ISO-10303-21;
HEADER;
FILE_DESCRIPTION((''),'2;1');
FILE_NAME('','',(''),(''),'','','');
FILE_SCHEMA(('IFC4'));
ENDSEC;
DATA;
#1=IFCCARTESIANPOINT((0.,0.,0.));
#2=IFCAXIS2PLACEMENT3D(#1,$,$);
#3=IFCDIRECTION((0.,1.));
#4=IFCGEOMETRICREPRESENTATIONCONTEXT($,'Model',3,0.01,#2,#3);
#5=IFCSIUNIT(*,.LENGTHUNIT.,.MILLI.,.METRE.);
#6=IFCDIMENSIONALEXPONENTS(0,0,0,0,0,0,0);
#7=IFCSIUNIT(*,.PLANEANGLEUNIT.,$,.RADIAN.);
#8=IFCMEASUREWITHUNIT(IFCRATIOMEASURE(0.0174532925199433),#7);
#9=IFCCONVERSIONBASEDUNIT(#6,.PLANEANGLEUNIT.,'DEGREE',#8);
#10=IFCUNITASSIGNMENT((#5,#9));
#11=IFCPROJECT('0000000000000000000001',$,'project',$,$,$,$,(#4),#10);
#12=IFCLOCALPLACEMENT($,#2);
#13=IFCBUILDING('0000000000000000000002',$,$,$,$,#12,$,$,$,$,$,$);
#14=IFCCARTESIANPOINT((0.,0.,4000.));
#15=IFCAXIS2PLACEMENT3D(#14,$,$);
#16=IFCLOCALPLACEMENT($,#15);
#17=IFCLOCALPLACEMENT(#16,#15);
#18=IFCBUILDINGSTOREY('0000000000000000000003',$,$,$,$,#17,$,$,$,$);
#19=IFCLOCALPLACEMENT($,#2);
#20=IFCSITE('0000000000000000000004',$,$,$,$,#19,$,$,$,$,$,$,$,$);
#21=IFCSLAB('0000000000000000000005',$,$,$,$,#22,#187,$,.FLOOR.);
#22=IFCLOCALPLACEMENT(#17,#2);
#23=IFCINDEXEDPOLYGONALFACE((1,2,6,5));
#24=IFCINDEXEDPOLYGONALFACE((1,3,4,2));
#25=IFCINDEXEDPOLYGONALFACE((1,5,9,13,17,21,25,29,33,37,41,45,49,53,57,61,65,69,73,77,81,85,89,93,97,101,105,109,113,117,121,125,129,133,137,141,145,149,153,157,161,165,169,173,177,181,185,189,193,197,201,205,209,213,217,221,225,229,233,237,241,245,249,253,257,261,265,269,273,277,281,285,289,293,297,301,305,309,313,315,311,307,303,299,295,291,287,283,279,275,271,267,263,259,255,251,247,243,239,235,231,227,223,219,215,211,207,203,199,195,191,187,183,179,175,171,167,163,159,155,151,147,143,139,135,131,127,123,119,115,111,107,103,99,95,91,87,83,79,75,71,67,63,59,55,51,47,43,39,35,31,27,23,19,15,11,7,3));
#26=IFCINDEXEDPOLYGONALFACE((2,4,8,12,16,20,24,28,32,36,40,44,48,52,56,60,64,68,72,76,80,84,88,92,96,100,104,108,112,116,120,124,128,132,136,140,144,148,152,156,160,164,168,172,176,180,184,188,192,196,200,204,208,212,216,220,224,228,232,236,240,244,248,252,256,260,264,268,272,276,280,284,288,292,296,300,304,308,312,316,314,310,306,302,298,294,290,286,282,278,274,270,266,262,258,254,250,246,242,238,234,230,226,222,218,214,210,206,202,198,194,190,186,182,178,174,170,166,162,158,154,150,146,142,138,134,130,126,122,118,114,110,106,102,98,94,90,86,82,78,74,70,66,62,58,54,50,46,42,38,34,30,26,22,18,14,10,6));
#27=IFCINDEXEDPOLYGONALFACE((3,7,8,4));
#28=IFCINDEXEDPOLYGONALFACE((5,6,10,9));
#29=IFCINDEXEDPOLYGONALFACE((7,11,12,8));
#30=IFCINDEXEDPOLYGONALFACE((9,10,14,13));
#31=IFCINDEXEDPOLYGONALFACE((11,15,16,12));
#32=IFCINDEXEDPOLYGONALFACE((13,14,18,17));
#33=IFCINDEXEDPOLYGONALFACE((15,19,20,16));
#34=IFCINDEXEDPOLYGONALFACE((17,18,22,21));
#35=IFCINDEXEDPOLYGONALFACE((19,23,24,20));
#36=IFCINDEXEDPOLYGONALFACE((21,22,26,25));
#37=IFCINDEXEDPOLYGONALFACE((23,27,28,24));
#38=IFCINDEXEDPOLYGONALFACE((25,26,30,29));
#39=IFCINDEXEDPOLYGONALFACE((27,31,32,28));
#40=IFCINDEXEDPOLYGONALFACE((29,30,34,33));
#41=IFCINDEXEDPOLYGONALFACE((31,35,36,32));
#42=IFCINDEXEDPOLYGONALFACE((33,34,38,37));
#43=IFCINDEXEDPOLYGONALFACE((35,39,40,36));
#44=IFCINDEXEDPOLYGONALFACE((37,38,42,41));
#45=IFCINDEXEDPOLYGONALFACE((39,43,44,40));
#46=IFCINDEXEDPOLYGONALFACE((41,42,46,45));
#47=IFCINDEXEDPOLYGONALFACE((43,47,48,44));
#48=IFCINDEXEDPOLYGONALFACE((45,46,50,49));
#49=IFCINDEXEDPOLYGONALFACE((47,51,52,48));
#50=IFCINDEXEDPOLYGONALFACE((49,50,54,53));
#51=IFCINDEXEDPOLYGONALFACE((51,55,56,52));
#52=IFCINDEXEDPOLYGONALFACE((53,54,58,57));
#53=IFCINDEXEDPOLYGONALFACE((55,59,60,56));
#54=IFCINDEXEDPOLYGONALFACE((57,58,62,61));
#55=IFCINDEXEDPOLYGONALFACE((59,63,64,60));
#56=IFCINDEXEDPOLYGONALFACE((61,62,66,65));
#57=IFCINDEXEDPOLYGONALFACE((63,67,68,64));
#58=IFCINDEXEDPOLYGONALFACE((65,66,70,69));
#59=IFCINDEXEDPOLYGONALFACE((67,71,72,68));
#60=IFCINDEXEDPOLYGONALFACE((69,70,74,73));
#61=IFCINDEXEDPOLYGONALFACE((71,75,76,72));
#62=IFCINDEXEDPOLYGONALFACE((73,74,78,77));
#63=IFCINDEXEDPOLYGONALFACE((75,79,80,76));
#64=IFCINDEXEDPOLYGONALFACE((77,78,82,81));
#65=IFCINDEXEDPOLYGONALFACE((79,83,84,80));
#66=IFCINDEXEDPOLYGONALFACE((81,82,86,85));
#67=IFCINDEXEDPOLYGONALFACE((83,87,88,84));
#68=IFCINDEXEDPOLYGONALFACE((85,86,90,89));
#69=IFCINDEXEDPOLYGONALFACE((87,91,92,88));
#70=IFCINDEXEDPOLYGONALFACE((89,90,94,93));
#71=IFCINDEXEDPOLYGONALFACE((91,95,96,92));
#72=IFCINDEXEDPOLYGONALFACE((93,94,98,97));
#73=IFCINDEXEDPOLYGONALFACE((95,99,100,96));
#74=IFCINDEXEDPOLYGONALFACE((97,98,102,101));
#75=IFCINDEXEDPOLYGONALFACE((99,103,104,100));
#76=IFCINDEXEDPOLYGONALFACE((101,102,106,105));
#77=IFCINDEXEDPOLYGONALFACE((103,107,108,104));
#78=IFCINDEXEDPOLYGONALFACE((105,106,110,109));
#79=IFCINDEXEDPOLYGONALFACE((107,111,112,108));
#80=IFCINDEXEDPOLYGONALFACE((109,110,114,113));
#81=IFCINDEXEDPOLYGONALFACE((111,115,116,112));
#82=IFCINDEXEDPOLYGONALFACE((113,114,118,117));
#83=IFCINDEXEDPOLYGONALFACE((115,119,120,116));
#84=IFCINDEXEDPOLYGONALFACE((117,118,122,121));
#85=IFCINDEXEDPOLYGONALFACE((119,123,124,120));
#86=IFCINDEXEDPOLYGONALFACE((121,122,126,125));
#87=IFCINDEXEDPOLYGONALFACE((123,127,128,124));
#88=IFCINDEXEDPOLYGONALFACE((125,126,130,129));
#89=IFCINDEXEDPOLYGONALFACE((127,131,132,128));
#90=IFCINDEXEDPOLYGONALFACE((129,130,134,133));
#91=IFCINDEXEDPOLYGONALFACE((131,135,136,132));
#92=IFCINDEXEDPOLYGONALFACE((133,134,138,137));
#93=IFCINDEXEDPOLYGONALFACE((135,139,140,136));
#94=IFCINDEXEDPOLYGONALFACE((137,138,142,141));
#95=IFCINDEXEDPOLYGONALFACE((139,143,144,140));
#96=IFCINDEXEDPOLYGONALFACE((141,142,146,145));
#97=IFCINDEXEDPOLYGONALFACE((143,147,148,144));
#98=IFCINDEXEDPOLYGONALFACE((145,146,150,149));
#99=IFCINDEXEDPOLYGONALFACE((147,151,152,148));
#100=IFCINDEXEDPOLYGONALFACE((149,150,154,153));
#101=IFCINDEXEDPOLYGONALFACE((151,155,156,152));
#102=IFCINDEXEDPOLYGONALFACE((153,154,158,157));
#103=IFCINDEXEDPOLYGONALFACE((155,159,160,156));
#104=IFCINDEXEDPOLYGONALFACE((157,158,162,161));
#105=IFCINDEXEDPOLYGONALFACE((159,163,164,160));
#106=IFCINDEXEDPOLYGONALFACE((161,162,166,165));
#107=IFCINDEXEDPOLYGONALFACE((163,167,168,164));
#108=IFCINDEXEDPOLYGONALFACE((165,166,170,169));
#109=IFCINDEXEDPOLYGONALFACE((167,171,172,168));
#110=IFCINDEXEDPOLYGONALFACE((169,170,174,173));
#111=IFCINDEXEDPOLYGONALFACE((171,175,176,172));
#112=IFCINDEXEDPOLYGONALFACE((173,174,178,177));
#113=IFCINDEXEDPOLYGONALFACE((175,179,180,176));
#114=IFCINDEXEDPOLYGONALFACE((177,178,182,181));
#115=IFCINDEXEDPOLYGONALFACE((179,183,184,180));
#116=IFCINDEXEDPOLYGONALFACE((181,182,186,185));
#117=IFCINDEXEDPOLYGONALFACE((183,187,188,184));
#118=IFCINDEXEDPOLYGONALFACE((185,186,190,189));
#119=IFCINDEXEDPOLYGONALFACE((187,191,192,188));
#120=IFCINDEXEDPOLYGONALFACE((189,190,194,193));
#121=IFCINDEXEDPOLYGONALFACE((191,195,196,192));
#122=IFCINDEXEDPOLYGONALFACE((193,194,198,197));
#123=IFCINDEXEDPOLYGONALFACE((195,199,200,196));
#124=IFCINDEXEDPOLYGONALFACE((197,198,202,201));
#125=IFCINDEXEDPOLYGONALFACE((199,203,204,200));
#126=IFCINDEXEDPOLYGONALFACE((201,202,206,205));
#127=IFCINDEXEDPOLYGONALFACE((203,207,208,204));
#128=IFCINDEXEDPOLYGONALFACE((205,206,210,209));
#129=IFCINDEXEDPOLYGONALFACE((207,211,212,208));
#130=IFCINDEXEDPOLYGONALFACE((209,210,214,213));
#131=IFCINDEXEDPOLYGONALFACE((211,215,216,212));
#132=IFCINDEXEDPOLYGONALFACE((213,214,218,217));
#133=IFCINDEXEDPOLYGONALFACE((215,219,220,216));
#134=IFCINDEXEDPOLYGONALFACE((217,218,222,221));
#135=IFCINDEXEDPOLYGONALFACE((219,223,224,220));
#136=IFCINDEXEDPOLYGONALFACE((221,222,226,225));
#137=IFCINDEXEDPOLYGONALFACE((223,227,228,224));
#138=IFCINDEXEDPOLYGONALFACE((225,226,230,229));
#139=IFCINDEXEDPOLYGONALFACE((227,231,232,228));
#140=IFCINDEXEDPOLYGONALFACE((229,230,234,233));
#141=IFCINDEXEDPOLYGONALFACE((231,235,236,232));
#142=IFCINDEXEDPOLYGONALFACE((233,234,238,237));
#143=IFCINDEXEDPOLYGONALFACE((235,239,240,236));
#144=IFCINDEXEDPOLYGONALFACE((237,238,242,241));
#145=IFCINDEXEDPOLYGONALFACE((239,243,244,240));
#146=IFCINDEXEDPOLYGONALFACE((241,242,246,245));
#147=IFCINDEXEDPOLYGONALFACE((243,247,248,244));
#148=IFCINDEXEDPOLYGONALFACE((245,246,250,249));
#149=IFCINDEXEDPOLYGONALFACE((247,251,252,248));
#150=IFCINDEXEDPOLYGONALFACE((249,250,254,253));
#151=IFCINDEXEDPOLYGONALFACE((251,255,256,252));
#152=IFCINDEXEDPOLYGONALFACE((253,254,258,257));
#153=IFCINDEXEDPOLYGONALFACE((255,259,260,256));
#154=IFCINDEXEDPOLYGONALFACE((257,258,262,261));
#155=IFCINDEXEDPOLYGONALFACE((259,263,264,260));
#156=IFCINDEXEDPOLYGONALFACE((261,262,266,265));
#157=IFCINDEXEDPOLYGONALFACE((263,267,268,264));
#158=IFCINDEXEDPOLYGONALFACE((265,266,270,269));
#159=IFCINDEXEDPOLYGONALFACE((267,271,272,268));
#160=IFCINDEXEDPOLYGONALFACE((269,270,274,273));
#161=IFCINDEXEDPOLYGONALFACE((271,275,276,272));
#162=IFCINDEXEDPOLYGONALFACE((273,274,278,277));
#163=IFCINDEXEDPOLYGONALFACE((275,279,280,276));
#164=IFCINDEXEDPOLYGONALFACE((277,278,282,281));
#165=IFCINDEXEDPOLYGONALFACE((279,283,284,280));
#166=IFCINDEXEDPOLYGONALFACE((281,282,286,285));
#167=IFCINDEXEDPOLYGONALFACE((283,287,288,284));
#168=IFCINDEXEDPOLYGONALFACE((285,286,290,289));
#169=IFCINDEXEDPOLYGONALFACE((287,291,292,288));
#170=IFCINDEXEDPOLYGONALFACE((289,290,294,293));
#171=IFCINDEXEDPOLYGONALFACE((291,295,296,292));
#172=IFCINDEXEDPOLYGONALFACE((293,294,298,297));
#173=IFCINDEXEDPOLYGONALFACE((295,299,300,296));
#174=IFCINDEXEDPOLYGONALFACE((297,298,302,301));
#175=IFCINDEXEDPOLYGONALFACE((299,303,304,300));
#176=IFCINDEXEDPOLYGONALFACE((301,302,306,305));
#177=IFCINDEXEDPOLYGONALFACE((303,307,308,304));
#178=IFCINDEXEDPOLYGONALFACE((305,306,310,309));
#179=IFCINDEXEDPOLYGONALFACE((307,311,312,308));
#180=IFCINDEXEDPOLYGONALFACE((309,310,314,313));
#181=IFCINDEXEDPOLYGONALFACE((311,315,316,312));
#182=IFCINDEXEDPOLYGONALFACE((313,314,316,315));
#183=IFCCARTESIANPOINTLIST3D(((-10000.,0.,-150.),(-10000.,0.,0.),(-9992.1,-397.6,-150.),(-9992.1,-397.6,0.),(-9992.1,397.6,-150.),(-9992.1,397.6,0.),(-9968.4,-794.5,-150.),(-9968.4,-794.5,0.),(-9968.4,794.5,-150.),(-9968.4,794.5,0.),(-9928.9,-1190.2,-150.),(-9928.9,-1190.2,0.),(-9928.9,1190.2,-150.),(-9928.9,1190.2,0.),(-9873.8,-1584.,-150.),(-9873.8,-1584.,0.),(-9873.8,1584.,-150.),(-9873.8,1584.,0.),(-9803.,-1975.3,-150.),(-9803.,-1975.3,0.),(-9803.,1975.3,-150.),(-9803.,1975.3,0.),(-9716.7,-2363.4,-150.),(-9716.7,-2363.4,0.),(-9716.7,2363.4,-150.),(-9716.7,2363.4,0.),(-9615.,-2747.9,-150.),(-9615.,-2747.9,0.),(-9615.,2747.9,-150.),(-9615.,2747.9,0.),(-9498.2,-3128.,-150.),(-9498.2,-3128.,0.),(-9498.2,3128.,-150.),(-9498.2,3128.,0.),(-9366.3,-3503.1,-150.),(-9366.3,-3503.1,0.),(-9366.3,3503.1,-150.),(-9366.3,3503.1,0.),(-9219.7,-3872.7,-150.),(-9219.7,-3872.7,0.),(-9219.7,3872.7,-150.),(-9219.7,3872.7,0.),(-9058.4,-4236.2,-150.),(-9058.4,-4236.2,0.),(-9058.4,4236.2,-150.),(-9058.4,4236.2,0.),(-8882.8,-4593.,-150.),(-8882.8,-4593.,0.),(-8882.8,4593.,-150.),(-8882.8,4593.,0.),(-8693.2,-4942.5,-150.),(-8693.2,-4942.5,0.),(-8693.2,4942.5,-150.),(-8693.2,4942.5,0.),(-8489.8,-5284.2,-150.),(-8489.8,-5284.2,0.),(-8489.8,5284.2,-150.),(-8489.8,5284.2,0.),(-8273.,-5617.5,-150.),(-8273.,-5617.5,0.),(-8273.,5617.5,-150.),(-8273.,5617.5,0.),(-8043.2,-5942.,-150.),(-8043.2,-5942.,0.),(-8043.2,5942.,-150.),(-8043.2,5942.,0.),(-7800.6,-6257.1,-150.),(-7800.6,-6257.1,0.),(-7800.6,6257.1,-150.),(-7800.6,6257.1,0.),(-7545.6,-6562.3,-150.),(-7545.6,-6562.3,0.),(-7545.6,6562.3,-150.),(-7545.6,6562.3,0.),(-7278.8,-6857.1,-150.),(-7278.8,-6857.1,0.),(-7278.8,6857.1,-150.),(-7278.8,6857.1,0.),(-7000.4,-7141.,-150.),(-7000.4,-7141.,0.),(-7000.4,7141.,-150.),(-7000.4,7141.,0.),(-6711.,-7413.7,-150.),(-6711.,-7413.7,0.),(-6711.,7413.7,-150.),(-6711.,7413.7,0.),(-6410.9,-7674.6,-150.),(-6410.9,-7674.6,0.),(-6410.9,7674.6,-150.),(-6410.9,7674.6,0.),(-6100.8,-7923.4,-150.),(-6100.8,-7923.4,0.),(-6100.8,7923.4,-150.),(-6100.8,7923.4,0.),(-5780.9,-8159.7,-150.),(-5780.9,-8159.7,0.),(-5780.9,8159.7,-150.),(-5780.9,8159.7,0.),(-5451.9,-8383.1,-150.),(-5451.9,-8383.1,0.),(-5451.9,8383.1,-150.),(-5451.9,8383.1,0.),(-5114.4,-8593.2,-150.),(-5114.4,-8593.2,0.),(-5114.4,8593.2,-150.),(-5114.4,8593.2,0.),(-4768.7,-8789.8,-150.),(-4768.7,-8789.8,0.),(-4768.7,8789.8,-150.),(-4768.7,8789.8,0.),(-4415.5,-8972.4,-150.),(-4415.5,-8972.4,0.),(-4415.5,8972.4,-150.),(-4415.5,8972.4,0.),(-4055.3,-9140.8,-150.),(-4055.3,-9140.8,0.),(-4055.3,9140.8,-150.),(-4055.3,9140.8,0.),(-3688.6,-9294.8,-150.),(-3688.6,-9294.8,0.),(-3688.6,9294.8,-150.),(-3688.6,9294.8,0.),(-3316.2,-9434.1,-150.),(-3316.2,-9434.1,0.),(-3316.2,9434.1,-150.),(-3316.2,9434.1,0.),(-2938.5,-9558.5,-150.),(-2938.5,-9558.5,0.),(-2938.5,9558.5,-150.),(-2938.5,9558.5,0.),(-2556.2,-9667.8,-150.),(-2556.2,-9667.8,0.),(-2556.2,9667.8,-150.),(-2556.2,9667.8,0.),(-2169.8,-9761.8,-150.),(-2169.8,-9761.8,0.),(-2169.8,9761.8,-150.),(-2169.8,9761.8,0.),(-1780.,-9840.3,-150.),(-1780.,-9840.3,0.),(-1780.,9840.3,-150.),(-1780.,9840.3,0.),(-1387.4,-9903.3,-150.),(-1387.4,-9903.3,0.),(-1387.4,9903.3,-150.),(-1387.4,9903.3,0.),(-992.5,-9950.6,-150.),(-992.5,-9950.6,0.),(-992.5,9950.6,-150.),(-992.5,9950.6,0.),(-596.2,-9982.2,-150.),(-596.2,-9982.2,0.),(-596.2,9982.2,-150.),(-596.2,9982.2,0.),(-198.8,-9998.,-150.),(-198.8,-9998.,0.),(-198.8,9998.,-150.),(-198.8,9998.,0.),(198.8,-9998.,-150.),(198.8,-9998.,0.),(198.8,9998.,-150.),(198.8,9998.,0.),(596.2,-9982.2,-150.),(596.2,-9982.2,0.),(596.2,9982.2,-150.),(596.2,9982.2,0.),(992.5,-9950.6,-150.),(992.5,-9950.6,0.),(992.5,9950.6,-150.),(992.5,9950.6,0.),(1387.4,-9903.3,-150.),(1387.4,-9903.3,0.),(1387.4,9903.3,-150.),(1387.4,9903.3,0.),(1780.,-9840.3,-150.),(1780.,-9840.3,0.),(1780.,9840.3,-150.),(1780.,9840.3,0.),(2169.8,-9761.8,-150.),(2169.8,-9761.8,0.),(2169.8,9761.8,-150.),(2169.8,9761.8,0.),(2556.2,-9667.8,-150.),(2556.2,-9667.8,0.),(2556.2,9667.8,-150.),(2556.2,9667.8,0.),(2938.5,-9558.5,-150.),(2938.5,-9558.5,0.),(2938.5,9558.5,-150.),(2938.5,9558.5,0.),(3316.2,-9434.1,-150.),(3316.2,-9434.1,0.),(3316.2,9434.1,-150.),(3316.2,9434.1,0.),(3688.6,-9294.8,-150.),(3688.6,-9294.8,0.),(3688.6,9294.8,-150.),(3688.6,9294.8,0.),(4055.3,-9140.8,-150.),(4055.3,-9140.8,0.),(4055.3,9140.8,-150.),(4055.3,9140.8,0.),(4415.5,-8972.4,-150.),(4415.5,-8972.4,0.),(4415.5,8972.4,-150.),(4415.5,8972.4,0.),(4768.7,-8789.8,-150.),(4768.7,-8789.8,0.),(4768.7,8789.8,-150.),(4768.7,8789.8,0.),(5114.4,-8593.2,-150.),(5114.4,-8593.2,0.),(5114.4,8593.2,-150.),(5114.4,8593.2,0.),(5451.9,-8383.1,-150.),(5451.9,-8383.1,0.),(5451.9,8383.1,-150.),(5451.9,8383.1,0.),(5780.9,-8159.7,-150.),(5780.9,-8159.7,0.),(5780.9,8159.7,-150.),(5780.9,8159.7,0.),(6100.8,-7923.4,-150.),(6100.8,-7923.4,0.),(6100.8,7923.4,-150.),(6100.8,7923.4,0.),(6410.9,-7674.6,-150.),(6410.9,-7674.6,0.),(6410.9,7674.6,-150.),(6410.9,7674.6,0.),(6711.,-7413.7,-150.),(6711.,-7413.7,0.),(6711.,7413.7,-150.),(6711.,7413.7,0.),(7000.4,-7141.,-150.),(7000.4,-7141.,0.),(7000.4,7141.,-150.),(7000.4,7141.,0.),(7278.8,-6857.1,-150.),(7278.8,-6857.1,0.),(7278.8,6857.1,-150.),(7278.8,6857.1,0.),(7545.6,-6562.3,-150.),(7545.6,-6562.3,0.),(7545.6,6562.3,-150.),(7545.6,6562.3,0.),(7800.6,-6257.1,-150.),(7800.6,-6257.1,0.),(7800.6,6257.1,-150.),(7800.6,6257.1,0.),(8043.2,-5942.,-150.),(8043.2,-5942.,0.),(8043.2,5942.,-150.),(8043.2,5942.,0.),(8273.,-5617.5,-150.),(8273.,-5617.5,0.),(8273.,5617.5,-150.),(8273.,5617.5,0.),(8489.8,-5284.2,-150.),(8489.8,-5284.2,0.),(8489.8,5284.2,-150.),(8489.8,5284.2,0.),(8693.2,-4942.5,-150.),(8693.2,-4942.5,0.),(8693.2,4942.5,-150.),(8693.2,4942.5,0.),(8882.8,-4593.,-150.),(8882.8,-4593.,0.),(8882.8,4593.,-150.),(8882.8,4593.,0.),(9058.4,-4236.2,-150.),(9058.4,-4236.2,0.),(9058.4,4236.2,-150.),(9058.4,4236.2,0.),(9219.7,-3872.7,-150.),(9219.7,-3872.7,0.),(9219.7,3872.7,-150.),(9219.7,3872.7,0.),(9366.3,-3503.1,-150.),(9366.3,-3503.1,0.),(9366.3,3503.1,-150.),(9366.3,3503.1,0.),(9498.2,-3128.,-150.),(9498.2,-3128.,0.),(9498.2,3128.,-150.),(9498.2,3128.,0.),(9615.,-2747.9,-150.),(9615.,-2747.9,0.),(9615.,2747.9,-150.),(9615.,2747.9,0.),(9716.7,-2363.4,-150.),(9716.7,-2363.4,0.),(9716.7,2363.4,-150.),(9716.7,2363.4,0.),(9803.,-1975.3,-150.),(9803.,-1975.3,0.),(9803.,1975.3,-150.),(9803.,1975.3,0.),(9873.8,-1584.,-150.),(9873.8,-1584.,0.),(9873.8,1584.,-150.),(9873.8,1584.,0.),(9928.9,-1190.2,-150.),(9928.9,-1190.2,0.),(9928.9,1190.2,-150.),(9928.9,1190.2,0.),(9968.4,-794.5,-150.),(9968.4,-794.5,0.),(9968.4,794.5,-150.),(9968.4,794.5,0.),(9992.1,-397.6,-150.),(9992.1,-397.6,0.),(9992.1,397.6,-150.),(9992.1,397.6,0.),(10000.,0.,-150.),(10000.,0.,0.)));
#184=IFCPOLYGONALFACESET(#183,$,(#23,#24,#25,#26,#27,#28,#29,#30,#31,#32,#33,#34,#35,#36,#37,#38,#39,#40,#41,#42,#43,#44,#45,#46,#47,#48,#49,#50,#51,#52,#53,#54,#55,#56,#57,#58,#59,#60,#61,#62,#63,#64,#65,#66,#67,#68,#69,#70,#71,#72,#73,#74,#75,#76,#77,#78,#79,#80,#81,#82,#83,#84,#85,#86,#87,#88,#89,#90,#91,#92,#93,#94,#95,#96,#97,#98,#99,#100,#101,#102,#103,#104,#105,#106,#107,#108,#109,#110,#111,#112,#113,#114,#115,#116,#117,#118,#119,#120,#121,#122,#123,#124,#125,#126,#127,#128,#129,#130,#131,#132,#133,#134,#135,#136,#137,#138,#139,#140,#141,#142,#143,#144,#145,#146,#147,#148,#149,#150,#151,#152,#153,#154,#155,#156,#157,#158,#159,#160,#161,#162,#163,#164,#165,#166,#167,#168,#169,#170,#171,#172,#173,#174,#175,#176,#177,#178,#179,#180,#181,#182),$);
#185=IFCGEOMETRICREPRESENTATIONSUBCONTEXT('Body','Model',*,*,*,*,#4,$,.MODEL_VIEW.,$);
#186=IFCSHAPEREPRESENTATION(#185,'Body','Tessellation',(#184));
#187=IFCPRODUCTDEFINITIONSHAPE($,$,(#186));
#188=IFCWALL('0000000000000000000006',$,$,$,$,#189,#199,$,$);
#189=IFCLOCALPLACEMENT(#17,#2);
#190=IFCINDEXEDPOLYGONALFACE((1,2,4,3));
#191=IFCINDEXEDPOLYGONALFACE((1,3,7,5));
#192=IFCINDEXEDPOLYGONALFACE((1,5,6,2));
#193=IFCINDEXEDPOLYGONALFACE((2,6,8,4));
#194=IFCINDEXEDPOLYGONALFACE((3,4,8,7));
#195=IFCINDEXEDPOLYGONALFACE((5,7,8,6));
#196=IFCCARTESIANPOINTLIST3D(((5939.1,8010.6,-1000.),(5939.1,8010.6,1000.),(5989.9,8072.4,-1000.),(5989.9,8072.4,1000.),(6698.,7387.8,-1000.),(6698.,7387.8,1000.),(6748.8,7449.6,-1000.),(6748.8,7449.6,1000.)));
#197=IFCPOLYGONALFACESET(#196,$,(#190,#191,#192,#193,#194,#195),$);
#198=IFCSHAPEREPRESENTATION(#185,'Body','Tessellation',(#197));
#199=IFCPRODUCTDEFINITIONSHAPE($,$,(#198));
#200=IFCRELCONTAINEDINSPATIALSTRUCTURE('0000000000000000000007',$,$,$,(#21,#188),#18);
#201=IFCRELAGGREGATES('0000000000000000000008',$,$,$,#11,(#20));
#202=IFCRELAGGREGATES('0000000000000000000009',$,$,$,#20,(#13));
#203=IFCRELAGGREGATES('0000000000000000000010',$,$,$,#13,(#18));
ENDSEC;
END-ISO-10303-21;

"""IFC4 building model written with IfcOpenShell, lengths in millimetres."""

from ifc_helpers import new_model, entity, si_unit, converted_unit, direction, frame, origin, origin_2d, place, context, subcontext, project, spatial, rectangle, circle, extrude, element, save


model = new_model("IFC4")

# Units and contexts
model_context = context("Model", 3, precision=0.01, world=origin(), true_north=direction((0.0, 1.0)))
body_context = subcontext(model_context, "Body", "Model", "MODEL_VIEW")
ifc_project = project(units=[si_unit("LENGTHUNIT", "METRE", prefix="MILLI"), converted_unit("PLANEANGLEUNIT", "DEGREE", entity("IfcRatioMeasure", 0.0174532925199433), si_unit("PLANEANGLEUNIT", "RADIAN"), dimensions=[0, 0, 0, 0, 0, 0, 0])], contexts=[model_context])

# Site, building, storey
site_placement = place(None, origin())
site = spatial("IfcSite", under=ifc_project, at=site_placement)
building_placement = place(None, origin())
building = spatial("IfcBuilding", under=site, at=building_placement)
placement = place(None, frame((0.0, 0.0, 4000.0)))
storey_placement = place(placement, frame((0.0, 0.0, 4000.0)))
storey = spatial("IfcBuildingStorey", under=building, at=storey_placement)

# Slab
slab_placement = place(storey_placement, frame((0.0, 0.0, -150.0)))
element("IfcSlab", 1, at=slab_placement, inside=storey, PredefinedType="FLOOR", context=body_context, shape_type="SweptSolid", body=[
    extrude(circle(Radius=10000.0, at=origin_2d()), origin(), (0.0, 0.0, 1.0), 150.0),
])

# Wall
wall_1_placement = place(storey_placement, frame((6343.9, 7730.1, -1000.0), z_axis=(0.0, 0.0, 1.0), x_axis=(-7730.104548, 6343.932824, 0.0)))
element("IfcWall", 2, at=wall_1_placement, inside=storey, context=body_context, shape_type="SweptSolid", body=[
    extrude(rectangle(XDim=981.7, YDim=80.0, at=origin_2d()), origin(), (0.0, 0.0, 1.0), 2000.0),
])

save(model, "model.ifc")
